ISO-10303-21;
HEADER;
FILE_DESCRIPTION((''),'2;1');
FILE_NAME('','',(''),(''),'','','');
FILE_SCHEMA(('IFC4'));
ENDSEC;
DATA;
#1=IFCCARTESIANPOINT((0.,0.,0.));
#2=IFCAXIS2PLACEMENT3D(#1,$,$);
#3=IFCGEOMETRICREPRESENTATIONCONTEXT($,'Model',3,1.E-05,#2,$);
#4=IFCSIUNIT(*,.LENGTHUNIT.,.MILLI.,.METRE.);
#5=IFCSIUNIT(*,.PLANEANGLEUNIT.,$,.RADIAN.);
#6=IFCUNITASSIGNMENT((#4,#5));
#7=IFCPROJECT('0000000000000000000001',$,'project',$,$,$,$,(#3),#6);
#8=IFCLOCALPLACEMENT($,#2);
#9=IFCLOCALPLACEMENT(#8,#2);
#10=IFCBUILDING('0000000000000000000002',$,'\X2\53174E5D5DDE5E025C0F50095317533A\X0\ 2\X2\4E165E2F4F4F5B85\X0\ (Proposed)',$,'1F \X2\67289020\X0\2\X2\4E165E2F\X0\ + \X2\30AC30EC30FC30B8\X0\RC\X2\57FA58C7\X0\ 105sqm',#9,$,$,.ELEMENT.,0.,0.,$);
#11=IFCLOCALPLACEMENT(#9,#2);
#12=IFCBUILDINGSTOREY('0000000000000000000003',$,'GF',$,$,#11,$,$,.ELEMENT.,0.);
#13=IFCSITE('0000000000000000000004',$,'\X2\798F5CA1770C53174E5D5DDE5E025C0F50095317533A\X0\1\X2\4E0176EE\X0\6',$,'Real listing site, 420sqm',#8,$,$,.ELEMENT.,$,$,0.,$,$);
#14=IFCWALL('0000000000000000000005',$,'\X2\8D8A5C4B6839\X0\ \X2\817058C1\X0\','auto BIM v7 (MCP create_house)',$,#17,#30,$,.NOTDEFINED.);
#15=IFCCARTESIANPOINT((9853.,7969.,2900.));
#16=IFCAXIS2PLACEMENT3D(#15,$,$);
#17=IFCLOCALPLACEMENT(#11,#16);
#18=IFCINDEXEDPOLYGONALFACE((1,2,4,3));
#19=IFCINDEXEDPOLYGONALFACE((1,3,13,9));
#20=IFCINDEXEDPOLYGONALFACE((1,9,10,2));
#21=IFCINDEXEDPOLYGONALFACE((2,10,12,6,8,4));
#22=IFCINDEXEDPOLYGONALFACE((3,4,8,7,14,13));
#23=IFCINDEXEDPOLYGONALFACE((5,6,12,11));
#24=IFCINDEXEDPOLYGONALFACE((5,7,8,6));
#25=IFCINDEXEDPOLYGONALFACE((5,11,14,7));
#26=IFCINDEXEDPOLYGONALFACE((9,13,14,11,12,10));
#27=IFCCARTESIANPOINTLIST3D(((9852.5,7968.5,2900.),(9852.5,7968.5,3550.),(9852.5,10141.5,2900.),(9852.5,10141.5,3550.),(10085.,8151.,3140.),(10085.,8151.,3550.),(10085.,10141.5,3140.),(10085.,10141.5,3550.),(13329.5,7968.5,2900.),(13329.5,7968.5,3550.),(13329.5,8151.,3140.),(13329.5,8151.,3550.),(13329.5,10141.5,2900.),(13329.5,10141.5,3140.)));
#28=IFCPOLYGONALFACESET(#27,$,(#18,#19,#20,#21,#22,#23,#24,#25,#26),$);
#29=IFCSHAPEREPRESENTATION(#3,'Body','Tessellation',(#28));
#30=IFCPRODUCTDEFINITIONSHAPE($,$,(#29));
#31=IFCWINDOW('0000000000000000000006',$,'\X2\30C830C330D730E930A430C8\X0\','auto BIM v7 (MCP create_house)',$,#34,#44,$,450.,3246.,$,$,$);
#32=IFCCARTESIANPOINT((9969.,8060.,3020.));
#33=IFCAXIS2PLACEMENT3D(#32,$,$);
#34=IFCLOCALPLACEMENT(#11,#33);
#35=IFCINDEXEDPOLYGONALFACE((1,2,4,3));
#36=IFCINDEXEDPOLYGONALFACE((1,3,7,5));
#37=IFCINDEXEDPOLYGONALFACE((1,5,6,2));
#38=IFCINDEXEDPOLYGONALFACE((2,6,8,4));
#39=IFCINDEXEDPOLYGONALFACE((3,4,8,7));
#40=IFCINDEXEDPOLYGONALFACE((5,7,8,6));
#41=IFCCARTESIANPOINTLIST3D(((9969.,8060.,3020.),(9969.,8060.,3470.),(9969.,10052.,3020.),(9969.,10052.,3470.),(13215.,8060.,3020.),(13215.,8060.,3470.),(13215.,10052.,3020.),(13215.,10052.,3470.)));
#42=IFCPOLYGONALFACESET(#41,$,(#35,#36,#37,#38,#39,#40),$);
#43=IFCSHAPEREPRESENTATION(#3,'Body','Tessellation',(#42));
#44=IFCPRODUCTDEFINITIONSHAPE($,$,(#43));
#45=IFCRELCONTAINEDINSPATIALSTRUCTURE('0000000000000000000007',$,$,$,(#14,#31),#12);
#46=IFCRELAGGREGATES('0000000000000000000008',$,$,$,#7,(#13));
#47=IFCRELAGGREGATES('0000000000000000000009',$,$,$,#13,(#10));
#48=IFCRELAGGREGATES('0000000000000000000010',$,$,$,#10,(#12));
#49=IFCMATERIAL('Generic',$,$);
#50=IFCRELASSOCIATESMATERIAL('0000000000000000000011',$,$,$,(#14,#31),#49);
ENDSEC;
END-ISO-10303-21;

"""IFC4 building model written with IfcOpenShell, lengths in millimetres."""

from ifc_helpers import new_model, si_unit, frame, frame_2d, origin, place, context, project, spatial, rectangle, extrude, material, element, fill, save


model = new_model("IFC4")

# Units and contexts
model_context = context("Model", 3, precision=1e-05, world=origin())
ifc_project = project(units=[si_unit("LENGTHUNIT", "METRE", prefix="MILLI"), si_unit("PLANEANGLEUNIT", "RADIAN")], contexts=[model_context])

# Site, building, storey
site_placement = place(None, origin())
site = spatial("IfcSite", under=ifc_project, at=site_placement, Name="福岡県北九州市小倉北区1丁目6", ObjectType="Real listing site, 420sqm", CompositionType="ELEMENT", RefElevation=0.0)
building_placement = place(site_placement, origin())
building = spatial("IfcBuilding", under=site, at=building_placement, Name="北九州市小倉北区 2世帯住宅 (Proposed)", ObjectType="1F 木造2世帯 + ガレージRC基壇 105sqm", CompositionType="ELEMENT", ElevationOfRefHeight=0.0, ElevationOfTerrain=0.0)
storey_placement = place(building_placement, origin())
storey = spatial("IfcBuildingStorey", under=building, at=storey_placement, Name="GF", CompositionType="ELEMENT", Elevation=0.0)

# Shared definitions
ifc_material = material(Name="Generic")

# Wall, opening, window
wall_1_placement = place(storey_placement, frame((9853.0, 7969.0, 2900.0)))
wall_1 = element("IfcWall", 1, at=wall_1_placement, inside=storey, material=ifc_material, Name="越屋根 腰壁", Description="auto BIM v7 (MCP create_house)", PredefinedType="NOTDEFINED", context=model_context, shape_type="SweptSolid", body=[
    extrude(rectangle(XDim=3477.0, YDim=2173.0, at=frame_2d((1738.0, 1086.0))), frame((9853.0, 7969.0, 2900.0)), (0.0, 0.0, 1.0), 650.0),
])
opening_1_placement = place(storey_placement, frame((9969.0, 8060.0, 3020.0)))
opening_1 = element("IfcOpeningElement", 2, at=opening_1_placement, cuts=wall_1, PredefinedType="NOTDEFINED", context=model_context, shape_type="SweptSolid", body=[
    extrude(rectangle(XDim=3246.0, YDim=1992.0, at=frame_2d((1623.0, 996.0))), frame((9969.0, 8060.0, 3020.0)), (0.0, 0.0, 1.0), 450.0),
])
window_1_placement = place(storey_placement, frame((9969.0, 8060.0, 3020.0)))
window_1 = element("IfcWindow", 3, at=window_1_placement, inside=storey, material=ifc_material, Name="トップライト", Description="auto BIM v7 (MCP create_house)", OverallHeight=450.0, OverallWidth=3246.0, context=model_context, shape_type="SweptSolid", body=[
    extrude(rectangle(XDim=3246.0, YDim=1992.0, at=frame_2d((1623.0, 996.0))), frame((9969.0, 8060.0, 3020.0)), (0.0, 0.0, 1.0), 450.0),
])
fill(opening_1, window_1)

save(model, "model.ifc")
